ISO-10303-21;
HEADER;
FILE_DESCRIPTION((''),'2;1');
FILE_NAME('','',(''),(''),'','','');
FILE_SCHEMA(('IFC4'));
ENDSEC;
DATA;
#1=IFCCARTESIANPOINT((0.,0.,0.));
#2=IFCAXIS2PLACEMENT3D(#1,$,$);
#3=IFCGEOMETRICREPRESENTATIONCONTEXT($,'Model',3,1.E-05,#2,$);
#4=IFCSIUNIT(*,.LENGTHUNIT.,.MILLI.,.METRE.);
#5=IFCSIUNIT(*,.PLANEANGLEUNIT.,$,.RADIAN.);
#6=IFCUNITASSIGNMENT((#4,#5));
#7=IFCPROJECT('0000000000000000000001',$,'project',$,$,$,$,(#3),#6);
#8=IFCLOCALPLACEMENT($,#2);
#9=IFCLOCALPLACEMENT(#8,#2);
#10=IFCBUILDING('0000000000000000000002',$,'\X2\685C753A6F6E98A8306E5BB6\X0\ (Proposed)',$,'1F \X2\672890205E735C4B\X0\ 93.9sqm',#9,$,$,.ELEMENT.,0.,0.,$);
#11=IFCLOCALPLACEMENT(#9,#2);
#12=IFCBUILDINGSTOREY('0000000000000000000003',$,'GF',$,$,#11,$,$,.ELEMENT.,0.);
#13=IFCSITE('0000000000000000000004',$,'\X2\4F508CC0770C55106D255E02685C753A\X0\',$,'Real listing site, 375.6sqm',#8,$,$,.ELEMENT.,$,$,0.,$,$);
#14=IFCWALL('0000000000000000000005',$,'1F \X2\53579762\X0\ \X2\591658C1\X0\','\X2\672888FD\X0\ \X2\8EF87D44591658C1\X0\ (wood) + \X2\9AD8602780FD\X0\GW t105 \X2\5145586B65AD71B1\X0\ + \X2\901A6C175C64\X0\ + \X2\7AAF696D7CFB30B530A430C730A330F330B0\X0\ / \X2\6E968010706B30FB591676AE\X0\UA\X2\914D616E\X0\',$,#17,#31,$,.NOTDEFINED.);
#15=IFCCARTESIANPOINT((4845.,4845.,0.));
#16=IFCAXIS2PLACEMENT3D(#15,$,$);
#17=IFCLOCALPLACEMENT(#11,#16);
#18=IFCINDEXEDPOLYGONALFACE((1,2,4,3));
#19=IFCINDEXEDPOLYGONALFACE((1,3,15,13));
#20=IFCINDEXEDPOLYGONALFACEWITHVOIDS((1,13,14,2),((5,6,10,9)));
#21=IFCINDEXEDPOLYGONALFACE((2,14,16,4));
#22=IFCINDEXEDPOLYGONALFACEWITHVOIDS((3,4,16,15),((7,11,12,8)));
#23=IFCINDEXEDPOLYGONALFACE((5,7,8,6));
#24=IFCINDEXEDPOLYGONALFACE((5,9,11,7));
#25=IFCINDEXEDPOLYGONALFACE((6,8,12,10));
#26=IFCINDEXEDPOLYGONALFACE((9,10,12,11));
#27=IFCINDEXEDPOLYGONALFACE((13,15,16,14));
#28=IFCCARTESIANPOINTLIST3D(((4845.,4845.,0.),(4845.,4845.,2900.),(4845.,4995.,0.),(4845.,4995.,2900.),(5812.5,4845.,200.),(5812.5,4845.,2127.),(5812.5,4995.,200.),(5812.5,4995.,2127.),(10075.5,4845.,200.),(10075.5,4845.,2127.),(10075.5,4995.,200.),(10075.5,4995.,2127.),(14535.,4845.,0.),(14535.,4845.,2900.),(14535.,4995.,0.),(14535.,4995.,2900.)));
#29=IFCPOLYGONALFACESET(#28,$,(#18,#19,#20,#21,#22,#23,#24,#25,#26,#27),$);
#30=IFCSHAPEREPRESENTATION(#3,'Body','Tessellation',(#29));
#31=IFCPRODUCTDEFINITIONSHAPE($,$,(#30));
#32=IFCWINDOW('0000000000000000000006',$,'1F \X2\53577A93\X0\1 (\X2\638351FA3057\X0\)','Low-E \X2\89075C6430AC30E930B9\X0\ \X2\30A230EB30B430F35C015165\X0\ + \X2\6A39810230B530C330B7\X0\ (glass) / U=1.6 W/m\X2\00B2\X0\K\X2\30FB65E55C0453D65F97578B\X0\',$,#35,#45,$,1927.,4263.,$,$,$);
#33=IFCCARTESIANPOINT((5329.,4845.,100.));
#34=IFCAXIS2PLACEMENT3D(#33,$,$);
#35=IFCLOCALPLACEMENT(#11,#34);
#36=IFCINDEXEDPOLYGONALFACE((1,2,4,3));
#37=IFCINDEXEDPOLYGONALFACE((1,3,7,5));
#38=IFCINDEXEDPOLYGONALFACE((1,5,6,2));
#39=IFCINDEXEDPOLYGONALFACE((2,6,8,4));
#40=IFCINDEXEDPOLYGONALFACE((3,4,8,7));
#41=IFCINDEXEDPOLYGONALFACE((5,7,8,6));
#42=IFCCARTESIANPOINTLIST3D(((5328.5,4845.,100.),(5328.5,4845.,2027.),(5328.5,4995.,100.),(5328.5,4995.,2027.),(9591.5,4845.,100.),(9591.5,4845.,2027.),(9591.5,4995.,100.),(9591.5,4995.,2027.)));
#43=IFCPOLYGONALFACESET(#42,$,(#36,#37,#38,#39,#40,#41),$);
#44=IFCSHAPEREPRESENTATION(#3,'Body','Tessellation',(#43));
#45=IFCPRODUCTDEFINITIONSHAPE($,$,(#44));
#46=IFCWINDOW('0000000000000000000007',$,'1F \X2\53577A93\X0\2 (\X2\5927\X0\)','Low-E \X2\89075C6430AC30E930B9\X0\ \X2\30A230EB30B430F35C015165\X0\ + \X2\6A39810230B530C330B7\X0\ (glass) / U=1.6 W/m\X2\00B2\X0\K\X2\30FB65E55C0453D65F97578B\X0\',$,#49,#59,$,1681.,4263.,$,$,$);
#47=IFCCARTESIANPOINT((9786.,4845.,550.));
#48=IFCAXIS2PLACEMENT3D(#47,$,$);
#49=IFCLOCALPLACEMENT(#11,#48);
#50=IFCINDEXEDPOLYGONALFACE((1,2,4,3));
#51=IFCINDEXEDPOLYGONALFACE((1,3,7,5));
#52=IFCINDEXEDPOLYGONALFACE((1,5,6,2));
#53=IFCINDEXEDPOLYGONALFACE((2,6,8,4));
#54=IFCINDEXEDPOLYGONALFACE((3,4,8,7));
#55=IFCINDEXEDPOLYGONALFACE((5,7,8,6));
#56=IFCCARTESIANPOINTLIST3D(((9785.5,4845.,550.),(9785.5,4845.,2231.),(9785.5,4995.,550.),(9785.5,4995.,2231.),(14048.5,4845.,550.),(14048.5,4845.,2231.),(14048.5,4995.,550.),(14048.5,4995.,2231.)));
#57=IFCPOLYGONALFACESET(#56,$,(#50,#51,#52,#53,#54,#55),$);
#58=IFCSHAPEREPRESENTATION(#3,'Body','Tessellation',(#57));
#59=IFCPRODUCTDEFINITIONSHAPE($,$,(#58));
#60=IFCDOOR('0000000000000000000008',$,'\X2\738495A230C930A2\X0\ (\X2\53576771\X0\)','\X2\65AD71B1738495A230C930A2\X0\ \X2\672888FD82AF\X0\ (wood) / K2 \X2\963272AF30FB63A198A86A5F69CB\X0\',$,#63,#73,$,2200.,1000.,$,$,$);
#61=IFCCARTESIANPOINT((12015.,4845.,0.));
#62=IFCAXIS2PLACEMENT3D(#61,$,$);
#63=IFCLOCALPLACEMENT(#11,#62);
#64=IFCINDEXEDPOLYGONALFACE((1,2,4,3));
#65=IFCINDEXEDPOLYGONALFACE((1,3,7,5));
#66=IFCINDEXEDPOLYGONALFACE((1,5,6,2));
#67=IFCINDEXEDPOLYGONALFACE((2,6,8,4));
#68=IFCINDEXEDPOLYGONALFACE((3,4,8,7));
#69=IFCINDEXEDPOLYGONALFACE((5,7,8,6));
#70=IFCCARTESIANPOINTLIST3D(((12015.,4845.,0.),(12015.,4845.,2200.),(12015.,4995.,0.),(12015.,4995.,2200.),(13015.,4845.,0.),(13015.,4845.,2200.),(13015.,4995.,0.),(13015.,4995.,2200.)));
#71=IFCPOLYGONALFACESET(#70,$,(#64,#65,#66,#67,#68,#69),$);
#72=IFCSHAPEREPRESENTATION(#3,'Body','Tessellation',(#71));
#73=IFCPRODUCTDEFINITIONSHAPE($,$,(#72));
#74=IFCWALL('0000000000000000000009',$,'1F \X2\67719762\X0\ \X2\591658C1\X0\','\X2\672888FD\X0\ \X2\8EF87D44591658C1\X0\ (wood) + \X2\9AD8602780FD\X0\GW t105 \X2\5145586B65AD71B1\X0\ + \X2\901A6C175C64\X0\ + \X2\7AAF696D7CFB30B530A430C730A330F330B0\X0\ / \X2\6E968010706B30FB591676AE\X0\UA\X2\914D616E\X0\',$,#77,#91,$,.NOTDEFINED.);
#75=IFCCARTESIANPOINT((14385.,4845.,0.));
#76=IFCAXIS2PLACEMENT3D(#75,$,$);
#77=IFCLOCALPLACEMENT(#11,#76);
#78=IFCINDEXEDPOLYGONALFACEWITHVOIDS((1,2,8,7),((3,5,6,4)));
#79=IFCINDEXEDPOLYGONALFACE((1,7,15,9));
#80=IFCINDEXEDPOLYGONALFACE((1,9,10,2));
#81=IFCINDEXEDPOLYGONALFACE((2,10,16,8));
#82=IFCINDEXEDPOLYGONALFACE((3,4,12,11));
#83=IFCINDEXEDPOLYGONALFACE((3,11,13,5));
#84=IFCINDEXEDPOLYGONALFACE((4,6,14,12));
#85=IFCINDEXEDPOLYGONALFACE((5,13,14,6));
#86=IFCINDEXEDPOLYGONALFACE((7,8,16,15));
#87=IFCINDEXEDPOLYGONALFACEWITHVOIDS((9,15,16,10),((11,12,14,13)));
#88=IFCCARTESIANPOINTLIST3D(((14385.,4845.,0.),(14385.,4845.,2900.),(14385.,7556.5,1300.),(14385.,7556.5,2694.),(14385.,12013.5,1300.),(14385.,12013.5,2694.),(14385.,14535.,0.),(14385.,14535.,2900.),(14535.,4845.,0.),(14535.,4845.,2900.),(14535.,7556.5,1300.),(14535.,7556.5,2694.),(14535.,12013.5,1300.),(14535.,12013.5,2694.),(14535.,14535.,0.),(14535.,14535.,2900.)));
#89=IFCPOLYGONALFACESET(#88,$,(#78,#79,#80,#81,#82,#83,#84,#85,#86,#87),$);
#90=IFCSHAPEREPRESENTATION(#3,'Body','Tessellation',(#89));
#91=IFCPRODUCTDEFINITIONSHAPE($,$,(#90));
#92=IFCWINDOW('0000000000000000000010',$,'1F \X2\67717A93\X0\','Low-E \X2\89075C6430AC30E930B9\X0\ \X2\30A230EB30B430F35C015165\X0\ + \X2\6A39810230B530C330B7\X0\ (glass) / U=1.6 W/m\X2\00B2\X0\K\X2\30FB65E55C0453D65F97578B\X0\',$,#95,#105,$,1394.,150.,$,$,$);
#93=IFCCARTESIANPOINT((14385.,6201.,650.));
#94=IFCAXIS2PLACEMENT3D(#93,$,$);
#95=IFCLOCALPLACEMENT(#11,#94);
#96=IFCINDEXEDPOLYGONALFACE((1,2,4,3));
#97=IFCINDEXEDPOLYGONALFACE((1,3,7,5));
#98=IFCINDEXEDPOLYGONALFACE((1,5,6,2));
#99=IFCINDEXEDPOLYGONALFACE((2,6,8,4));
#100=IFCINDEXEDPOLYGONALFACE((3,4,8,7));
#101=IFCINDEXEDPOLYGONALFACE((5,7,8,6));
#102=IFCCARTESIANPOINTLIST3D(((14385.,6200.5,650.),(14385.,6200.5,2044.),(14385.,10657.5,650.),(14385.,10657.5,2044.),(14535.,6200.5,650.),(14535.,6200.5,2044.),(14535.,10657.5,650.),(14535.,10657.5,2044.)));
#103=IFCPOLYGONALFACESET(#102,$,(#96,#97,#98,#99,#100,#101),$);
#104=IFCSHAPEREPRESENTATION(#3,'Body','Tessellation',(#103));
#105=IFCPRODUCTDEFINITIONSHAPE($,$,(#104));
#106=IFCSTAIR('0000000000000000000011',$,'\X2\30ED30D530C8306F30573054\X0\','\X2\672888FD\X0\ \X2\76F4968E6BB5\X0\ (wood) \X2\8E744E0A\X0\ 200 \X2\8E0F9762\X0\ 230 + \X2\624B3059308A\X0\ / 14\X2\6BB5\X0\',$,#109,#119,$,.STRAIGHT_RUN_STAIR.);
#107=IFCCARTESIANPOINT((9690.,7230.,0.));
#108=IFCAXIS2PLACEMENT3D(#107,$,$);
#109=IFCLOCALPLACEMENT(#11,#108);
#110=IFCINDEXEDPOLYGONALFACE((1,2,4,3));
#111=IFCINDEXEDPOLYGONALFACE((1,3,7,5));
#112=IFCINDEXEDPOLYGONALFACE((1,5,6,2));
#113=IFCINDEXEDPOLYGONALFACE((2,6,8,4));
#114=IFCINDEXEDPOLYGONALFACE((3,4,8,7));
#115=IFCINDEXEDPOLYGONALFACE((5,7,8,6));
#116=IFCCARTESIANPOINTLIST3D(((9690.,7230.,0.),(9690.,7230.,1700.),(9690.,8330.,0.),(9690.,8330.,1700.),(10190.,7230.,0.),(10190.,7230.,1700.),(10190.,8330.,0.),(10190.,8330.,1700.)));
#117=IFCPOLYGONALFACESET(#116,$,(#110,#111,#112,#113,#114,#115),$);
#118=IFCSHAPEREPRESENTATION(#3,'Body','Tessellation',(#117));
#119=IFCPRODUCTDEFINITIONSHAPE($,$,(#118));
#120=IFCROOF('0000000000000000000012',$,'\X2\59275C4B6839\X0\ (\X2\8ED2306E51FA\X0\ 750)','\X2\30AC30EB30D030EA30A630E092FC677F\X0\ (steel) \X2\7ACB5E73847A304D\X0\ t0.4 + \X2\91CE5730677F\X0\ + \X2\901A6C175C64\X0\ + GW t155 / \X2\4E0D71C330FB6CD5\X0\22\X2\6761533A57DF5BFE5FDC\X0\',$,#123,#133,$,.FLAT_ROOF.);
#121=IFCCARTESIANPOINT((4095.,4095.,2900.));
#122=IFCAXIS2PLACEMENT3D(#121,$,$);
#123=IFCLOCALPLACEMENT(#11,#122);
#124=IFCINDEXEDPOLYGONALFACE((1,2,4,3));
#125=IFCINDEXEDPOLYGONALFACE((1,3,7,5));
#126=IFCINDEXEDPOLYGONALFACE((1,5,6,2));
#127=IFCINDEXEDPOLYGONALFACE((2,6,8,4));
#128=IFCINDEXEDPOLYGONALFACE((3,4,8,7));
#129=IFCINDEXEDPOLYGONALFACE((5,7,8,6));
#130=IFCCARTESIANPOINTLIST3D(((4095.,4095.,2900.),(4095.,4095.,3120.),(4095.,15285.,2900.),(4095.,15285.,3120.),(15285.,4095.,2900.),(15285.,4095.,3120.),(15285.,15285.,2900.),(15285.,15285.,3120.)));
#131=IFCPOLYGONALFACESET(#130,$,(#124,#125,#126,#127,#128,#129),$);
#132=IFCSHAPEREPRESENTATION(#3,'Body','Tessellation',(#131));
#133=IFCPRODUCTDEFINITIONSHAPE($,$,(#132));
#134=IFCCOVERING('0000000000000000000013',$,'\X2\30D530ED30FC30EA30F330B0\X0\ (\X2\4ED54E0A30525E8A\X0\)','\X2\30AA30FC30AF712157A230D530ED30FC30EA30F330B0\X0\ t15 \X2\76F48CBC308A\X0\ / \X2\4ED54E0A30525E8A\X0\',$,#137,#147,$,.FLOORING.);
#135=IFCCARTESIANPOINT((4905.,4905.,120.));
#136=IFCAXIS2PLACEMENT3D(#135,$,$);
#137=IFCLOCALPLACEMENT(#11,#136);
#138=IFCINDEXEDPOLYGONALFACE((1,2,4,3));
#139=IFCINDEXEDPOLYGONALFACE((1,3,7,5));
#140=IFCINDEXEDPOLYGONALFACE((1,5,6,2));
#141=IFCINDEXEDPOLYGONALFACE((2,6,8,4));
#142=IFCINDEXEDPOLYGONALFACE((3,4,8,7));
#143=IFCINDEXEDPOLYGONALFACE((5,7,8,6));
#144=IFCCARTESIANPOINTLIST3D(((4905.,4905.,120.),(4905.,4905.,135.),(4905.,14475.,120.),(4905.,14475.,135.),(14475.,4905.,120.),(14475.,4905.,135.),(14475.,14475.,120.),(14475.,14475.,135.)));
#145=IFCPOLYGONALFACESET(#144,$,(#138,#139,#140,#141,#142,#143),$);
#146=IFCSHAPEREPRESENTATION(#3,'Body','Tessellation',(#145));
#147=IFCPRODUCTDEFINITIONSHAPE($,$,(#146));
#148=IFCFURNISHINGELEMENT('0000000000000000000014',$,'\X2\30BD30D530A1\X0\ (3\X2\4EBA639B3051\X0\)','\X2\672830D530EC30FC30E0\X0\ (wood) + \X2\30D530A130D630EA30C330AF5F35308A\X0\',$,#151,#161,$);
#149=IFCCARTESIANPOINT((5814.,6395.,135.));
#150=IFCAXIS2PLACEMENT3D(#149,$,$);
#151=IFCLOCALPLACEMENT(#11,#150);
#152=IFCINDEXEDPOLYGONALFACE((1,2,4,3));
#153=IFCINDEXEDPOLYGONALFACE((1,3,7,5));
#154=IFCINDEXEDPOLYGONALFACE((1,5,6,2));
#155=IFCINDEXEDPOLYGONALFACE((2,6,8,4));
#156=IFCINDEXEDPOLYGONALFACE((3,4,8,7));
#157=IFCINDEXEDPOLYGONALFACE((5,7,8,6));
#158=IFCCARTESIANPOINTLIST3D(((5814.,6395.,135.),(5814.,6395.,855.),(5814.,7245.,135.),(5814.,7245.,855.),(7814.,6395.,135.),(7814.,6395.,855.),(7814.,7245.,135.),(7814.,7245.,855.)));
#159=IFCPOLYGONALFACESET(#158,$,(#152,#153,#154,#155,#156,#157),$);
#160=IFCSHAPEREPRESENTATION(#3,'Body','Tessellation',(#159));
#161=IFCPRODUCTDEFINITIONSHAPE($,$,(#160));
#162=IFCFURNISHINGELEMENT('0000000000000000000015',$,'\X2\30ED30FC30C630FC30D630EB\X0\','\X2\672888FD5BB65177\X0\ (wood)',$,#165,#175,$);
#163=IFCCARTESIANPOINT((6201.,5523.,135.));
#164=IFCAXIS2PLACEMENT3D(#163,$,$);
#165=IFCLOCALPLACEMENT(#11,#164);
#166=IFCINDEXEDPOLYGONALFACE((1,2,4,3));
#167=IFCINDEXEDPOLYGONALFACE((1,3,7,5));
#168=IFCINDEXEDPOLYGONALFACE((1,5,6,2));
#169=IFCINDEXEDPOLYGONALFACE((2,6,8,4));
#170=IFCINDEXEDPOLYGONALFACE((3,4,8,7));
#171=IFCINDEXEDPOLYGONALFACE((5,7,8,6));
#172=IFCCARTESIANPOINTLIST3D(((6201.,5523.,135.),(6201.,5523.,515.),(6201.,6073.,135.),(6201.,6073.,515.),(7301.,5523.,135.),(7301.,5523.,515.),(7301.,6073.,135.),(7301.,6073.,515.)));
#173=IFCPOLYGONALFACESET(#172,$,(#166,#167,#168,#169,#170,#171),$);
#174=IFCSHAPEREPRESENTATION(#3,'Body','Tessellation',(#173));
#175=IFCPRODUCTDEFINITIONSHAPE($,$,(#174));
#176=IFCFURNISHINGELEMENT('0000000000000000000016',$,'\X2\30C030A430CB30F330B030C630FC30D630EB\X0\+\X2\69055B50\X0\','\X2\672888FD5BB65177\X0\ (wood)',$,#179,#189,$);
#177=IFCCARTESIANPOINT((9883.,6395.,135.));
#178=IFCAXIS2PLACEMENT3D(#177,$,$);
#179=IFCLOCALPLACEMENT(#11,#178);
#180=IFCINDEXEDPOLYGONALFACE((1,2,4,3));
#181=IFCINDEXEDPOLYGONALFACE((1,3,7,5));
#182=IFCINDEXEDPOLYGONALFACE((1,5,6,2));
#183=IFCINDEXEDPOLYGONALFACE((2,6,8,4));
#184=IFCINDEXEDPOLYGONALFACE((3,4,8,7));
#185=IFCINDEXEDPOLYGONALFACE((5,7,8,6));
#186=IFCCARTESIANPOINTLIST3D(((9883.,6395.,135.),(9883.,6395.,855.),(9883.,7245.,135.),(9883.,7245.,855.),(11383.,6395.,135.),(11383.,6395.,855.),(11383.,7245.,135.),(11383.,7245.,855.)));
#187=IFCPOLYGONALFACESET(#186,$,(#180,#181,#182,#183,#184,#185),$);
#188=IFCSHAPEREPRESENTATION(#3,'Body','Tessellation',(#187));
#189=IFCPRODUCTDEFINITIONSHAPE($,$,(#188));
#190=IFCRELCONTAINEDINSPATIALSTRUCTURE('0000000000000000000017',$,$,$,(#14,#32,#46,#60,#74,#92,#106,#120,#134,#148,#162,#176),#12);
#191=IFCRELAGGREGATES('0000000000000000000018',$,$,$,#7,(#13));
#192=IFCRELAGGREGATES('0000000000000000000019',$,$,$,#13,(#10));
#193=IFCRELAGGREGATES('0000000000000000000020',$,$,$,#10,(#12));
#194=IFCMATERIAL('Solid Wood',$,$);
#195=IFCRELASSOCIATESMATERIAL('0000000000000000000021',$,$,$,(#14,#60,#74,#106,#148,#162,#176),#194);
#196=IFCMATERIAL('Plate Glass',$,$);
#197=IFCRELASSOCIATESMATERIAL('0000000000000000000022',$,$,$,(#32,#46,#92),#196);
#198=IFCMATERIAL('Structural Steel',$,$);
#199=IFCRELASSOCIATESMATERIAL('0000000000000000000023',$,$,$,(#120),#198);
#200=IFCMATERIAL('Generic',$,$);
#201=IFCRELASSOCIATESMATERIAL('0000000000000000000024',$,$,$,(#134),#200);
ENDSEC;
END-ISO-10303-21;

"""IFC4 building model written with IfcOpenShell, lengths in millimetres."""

from ifc_helpers import new_model, si_unit, frame, frame_2d, origin, place, context, project, spatial, rectangle, extrude, material, element, fill, save


model = new_model("IFC4")

# Units and contexts
model_context = context("Model", 3, precision=1e-05, world=origin())
ifc_project = project(units=[si_unit("LENGTHUNIT", "METRE", prefix="MILLI"), si_unit("PLANEANGLEUNIT", "RADIAN")], contexts=[model_context])

# Site, building, storey
site_placement = place(None, origin())
site = spatial("IfcSite", under=ifc_project, at=site_placement, Name="佐賀県唐津市桜町", ObjectType="Real listing site, 375.6sqm", CompositionType="ELEMENT", RefElevation=0.0)
building_placement = place(site_placement, origin())
building = spatial("IfcBuilding", under=site, at=building_placement, Name="桜町潮風の家 (Proposed)", ObjectType="1F 木造平屋 93.9sqm", CompositionType="ELEMENT", ElevationOfRefHeight=0.0, ElevationOfTerrain=0.0)
storey_placement = place(building_placement, origin())
storey = spatial("IfcBuildingStorey", under=building, at=storey_placement, Name="GF", CompositionType="ELEMENT", Elevation=0.0)

# Shared definitions
ifc_material_1 = material(Name="Solid Wood")

# Wall, openings, windows, door
wall_1_placement = place(storey_placement, frame((4845.0, 4845.0, 0.0)))
wall_1 = element("IfcWall", 1, at=wall_1_placement, inside=storey, material=ifc_material_1, Name="1F 南面 外壁", Description="木製 軸組外壁 (wood) + 高性能GW t105 充填断熱 + 通気層 + 窯業系サイディング / 準耐火・外皮UA配慮", PredefinedType="NOTDEFINED", context=model_context, shape_type="SweptSolid", body=[
    extrude(rectangle(XDim=9690.0, YDim=150.0, at=frame_2d((4845.0, 75.0))), frame((4845.0, 4845.0, 0.0)), (0.0, 0.0, 1.0), 2900.0),
])
opening_1_placement = place(storey_placement, frame((5329.0, 4845.0, 100.0)))
opening_1 = element("IfcOpeningElement", 2, at=opening_1_placement, cuts=wall_1, PredefinedType="NOTDEFINED", context=model_context, shape_type="SweptSolid", body=[
    extrude(rectangle(XDim=4263.0, YDim=150.0, at=frame_2d((2131.0, 75.0))), frame((5329.0, 4845.0, 100.0)), (0.0, 0.0, 1.0), 1927.0),
])
opening_2_placement = place(storey_placement, frame((9786.0, 4845.0, 550.0)))
opening_2 = element("IfcOpeningElement", 3, at=opening_2_placement, cuts=wall_1, PredefinedType="NOTDEFINED", context=model_context, shape_type="SweptSolid", body=[
    extrude(rectangle(XDim=4263.0, YDim=150.0, at=frame_2d((2131.0, 75.0))), frame((9786.0, 4845.0, 550.0)), (0.0, 0.0, 1.0), 1681.0),
])
opening_3_placement = place(storey_placement, frame((12015.0, 4845.0, 0.0)))
opening_3 = element("IfcOpeningElement", 4, at=opening_3_placement, cuts=wall_1, PredefinedType="NOTDEFINED", context=model_context, shape_type="SweptSolid", body=[
    extrude(rectangle(XDim=1000.0, YDim=150.0, at=frame_2d((500.0, 75.0))), frame((12015.0, 4845.0, 0.0)), (0.0, 0.0, 1.0), 2200.0),
])
ifc_material_2 = material(Name="Plate Glass")
window_1_placement = place(storey_placement, frame((5329.0, 4845.0, 100.0)))
window_1 = element("IfcWindow", 5, at=window_1_placement, inside=storey, material=ifc_material_2, Name="1F 南窓1 (掃出し)", Description="Low-E 複層ガラス アルゴン封入 + 樹脂サッシ (glass) / U=1.6 W/m²K・日射取得型", OverallHeight=1927.0, OverallWidth=4263.0, context=model_context, shape_type="SweptSolid", body=[
    extrude(rectangle(XDim=4263.0, YDim=150.0, at=frame_2d((2131.0, 75.0))), frame((5329.0, 4845.0, 100.0)), (0.0, 0.0, 1.0), 1927.0),
])
fill(opening_1, window_1)
window_2_placement = place(storey_placement, frame((9786.0, 4845.0, 550.0)))
window_2 = element("IfcWindow", 6, at=window_2_placement, inside=storey, material=ifc_material_2, Name="1F 南窓2 (大)", Description="Low-E 複層ガラス アルゴン封入 + 樹脂サッシ (glass) / U=1.6 W/m²K・日射取得型", OverallHeight=1681.0, OverallWidth=4263.0, context=model_context, shape_type="SweptSolid", body=[
    extrude(rectangle(XDim=4263.0, YDim=150.0, at=frame_2d((2131.0, 75.0))), frame((9786.0, 4845.0, 550.0)), (0.0, 0.0, 1.0), 1681.0),
])
fill(opening_2, window_2)
door_placement = place(storey_placement, frame((12015.0, 4845.0, 0.0)))
door = element("IfcDoor", 7, at=door_placement, inside=storey, material=ifc_material_1, Name="玄関ドア (南東)", Description="断熱玄関ドア 木製芯 (wood) / K2 防犯・採風機構", OverallHeight=2200.0, OverallWidth=1000.0, context=model_context, shape_type="SweptSolid", body=[
    extrude(rectangle(XDim=1000.0, YDim=150.0, at=frame_2d((500.0, 75.0))), frame((12015.0, 4845.0, 0.0)), (0.0, 0.0, 1.0), 2200.0),
])
fill(opening_3, door)

# Wall, opening, window
wall_2_placement = place(storey_placement, frame((14385.0, 4845.0, 0.0)))
wall_2 = element("IfcWall", 8, at=wall_2_placement, inside=storey, material=ifc_material_1, Name="1F 東面 外壁", Description="木製 軸組外壁 (wood) + 高性能GW t105 充填断熱 + 通気層 + 窯業系サイディング / 準耐火・外皮UA配慮", PredefinedType="NOTDEFINED", context=model_context, shape_type="SweptSolid", body=[
    extrude(rectangle(XDim=150.0, YDim=9690.0, at=frame_2d((75.0, 4845.0))), frame((14385.0, 4845.0, 0.0)), (0.0, 0.0, 1.0), 2900.0),
])
opening_4_placement = place(storey_placement, frame((14385.0, 6201.0, 650.0)))
opening_4 = element("IfcOpeningElement", 9, at=opening_4_placement, cuts=wall_2, PredefinedType="NOTDEFINED", context=model_context, shape_type="SweptSolid", body=[
    extrude(rectangle(XDim=150.0, YDim=4457.0, at=frame_2d((75.0, 2228.0))), frame((14385.0, 6201.0, 650.0)), (0.0, 0.0, 1.0), 1394.0),
])
window_3_placement = place(storey_placement, frame((14385.0, 6201.0, 650.0)))
window_3 = element("IfcWindow", 10, at=window_3_placement, inside=storey, material=ifc_material_2, Name="1F 東窓", Description="Low-E 複層ガラス アルゴン封入 + 樹脂サッシ (glass) / U=1.6 W/m²K・日射取得型", OverallHeight=1394.0, OverallWidth=150.0, context=model_context, shape_type="SweptSolid", body=[
    extrude(rectangle(XDim=150.0, YDim=4457.0, at=frame_2d((75.0, 2228.0))), frame((14385.0, 6201.0, 650.0)), (0.0, 0.0, 1.0), 1394.0),
])
fill(opening_4, window_3)

# Stair
stair_placement = place(storey_placement, frame((9690.0, 7230.0, 0.0)))
element("IfcStair", 11, at=stair_placement, inside=storey, material=ifc_material_1, Name="ロフトはしご", Description="木製 直階段 (wood) 蹴上 200 踏面 230 + 手すり / 14段", PredefinedType="STRAIGHT_RUN_STAIR", context=model_context, shape_type="SweptSolid", body=[
    extrude(rectangle(XDim=500.0, YDim=1100.0, at=frame_2d((250.0, 550.0))), frame((9690.0, 7230.0, 0.0)), (0.0, 0.0, 1.0), 1700.0),
])

# Roof
ifc_material_3 = material(Name="Structural Steel")
roof_placement = place(storey_placement, frame((4095.0, 4095.0, 2900.0)))
element("IfcRoof", 12, at=roof_placement, inside=storey, material=ifc_material_3, Name="大屋根 (軒の出 750)", Description="ガルバリウム鋼板 (steel) 立平葺き t0.4 + 野地板 + 通気層 + GW t155 / 不燃・法22条区域対応", PredefinedType="FLAT_ROOF", context=model_context, shape_type="SweptSolid", body=[
    extrude(rectangle(XDim=11190.0, YDim=11190.0, at=frame_2d((5595.0, 5595.0))), frame((4095.0, 4095.0, 2900.0)), (0.0, 0.0, 1.0), 220.0),
])

# Covering
ifc_material_4 = material(Name="Generic")
covering_placement = place(storey_placement, frame((4905.0, 4905.0, 120.0)))
element("IfcCovering", 13, at=covering_placement, inside=storey, material=ifc_material_4, Name="フローリング (仕上げ床)", Description="オーク無垢フローリング t15 直貼り / 仕上げ床", PredefinedType="FLOORING", context=model_context, shape_type="SweptSolid", body=[
    extrude(rectangle(XDim=9570.0, YDim=9570.0, at=frame_2d((4785.0, 4785.0))), frame((4905.0, 4905.0, 120.0)), (0.0, 0.0, 1.0), 15.0),
])

# Furnishing elements
furnishing_1_placement = place(storey_placement, frame((5814.0, 6395.0, 135.0)))
element("IfcFurnishingElement", 14, at=furnishing_1_placement, inside=storey, material=ifc_material_1, Name="ソファ (3人掛け)", Description="木フレーム (wood) + ファブリック張り", context=model_context, shape_type="SweptSolid", body=[
    extrude(rectangle(XDim=2000.0, YDim=850.0, at=frame_2d((1000.0, 425.0))), frame((5814.0, 6395.0, 135.0)), (0.0, 0.0, 1.0), 720.0),
])
furnishing_2_placement = place(storey_placement, frame((6201.0, 5523.0, 135.0)))
element("IfcFurnishingElement", 15, at=furnishing_2_placement, inside=storey, material=ifc_material_1, Name="ローテーブル", Description="木製家具 (wood)", context=model_context, shape_type="SweptSolid", body=[
    extrude(rectangle(XDim=1100.0, YDim=550.0, at=frame_2d((550.0, 275.0))), frame((6201.0, 5523.0, 135.0)), (0.0, 0.0, 1.0), 380.0),
])
furnishing_3_placement = place(storey_placement, frame((9883.0, 6395.0, 135.0)))
element("IfcFurnishingElement", 16, at=furnishing_3_placement, inside=storey, material=ifc_material_1, Name="ダイニングテーブル+椅子", Description="木製家具 (wood)", context=model_context, shape_type="SweptSolid", body=[
    extrude(rectangle(XDim=1500.0, YDim=850.0, at=frame_2d((750.0, 425.0))), frame((9883.0, 6395.0, 135.0)), (0.0, 0.0, 1.0), 720.0),
])

save(model, "model.ifc")
